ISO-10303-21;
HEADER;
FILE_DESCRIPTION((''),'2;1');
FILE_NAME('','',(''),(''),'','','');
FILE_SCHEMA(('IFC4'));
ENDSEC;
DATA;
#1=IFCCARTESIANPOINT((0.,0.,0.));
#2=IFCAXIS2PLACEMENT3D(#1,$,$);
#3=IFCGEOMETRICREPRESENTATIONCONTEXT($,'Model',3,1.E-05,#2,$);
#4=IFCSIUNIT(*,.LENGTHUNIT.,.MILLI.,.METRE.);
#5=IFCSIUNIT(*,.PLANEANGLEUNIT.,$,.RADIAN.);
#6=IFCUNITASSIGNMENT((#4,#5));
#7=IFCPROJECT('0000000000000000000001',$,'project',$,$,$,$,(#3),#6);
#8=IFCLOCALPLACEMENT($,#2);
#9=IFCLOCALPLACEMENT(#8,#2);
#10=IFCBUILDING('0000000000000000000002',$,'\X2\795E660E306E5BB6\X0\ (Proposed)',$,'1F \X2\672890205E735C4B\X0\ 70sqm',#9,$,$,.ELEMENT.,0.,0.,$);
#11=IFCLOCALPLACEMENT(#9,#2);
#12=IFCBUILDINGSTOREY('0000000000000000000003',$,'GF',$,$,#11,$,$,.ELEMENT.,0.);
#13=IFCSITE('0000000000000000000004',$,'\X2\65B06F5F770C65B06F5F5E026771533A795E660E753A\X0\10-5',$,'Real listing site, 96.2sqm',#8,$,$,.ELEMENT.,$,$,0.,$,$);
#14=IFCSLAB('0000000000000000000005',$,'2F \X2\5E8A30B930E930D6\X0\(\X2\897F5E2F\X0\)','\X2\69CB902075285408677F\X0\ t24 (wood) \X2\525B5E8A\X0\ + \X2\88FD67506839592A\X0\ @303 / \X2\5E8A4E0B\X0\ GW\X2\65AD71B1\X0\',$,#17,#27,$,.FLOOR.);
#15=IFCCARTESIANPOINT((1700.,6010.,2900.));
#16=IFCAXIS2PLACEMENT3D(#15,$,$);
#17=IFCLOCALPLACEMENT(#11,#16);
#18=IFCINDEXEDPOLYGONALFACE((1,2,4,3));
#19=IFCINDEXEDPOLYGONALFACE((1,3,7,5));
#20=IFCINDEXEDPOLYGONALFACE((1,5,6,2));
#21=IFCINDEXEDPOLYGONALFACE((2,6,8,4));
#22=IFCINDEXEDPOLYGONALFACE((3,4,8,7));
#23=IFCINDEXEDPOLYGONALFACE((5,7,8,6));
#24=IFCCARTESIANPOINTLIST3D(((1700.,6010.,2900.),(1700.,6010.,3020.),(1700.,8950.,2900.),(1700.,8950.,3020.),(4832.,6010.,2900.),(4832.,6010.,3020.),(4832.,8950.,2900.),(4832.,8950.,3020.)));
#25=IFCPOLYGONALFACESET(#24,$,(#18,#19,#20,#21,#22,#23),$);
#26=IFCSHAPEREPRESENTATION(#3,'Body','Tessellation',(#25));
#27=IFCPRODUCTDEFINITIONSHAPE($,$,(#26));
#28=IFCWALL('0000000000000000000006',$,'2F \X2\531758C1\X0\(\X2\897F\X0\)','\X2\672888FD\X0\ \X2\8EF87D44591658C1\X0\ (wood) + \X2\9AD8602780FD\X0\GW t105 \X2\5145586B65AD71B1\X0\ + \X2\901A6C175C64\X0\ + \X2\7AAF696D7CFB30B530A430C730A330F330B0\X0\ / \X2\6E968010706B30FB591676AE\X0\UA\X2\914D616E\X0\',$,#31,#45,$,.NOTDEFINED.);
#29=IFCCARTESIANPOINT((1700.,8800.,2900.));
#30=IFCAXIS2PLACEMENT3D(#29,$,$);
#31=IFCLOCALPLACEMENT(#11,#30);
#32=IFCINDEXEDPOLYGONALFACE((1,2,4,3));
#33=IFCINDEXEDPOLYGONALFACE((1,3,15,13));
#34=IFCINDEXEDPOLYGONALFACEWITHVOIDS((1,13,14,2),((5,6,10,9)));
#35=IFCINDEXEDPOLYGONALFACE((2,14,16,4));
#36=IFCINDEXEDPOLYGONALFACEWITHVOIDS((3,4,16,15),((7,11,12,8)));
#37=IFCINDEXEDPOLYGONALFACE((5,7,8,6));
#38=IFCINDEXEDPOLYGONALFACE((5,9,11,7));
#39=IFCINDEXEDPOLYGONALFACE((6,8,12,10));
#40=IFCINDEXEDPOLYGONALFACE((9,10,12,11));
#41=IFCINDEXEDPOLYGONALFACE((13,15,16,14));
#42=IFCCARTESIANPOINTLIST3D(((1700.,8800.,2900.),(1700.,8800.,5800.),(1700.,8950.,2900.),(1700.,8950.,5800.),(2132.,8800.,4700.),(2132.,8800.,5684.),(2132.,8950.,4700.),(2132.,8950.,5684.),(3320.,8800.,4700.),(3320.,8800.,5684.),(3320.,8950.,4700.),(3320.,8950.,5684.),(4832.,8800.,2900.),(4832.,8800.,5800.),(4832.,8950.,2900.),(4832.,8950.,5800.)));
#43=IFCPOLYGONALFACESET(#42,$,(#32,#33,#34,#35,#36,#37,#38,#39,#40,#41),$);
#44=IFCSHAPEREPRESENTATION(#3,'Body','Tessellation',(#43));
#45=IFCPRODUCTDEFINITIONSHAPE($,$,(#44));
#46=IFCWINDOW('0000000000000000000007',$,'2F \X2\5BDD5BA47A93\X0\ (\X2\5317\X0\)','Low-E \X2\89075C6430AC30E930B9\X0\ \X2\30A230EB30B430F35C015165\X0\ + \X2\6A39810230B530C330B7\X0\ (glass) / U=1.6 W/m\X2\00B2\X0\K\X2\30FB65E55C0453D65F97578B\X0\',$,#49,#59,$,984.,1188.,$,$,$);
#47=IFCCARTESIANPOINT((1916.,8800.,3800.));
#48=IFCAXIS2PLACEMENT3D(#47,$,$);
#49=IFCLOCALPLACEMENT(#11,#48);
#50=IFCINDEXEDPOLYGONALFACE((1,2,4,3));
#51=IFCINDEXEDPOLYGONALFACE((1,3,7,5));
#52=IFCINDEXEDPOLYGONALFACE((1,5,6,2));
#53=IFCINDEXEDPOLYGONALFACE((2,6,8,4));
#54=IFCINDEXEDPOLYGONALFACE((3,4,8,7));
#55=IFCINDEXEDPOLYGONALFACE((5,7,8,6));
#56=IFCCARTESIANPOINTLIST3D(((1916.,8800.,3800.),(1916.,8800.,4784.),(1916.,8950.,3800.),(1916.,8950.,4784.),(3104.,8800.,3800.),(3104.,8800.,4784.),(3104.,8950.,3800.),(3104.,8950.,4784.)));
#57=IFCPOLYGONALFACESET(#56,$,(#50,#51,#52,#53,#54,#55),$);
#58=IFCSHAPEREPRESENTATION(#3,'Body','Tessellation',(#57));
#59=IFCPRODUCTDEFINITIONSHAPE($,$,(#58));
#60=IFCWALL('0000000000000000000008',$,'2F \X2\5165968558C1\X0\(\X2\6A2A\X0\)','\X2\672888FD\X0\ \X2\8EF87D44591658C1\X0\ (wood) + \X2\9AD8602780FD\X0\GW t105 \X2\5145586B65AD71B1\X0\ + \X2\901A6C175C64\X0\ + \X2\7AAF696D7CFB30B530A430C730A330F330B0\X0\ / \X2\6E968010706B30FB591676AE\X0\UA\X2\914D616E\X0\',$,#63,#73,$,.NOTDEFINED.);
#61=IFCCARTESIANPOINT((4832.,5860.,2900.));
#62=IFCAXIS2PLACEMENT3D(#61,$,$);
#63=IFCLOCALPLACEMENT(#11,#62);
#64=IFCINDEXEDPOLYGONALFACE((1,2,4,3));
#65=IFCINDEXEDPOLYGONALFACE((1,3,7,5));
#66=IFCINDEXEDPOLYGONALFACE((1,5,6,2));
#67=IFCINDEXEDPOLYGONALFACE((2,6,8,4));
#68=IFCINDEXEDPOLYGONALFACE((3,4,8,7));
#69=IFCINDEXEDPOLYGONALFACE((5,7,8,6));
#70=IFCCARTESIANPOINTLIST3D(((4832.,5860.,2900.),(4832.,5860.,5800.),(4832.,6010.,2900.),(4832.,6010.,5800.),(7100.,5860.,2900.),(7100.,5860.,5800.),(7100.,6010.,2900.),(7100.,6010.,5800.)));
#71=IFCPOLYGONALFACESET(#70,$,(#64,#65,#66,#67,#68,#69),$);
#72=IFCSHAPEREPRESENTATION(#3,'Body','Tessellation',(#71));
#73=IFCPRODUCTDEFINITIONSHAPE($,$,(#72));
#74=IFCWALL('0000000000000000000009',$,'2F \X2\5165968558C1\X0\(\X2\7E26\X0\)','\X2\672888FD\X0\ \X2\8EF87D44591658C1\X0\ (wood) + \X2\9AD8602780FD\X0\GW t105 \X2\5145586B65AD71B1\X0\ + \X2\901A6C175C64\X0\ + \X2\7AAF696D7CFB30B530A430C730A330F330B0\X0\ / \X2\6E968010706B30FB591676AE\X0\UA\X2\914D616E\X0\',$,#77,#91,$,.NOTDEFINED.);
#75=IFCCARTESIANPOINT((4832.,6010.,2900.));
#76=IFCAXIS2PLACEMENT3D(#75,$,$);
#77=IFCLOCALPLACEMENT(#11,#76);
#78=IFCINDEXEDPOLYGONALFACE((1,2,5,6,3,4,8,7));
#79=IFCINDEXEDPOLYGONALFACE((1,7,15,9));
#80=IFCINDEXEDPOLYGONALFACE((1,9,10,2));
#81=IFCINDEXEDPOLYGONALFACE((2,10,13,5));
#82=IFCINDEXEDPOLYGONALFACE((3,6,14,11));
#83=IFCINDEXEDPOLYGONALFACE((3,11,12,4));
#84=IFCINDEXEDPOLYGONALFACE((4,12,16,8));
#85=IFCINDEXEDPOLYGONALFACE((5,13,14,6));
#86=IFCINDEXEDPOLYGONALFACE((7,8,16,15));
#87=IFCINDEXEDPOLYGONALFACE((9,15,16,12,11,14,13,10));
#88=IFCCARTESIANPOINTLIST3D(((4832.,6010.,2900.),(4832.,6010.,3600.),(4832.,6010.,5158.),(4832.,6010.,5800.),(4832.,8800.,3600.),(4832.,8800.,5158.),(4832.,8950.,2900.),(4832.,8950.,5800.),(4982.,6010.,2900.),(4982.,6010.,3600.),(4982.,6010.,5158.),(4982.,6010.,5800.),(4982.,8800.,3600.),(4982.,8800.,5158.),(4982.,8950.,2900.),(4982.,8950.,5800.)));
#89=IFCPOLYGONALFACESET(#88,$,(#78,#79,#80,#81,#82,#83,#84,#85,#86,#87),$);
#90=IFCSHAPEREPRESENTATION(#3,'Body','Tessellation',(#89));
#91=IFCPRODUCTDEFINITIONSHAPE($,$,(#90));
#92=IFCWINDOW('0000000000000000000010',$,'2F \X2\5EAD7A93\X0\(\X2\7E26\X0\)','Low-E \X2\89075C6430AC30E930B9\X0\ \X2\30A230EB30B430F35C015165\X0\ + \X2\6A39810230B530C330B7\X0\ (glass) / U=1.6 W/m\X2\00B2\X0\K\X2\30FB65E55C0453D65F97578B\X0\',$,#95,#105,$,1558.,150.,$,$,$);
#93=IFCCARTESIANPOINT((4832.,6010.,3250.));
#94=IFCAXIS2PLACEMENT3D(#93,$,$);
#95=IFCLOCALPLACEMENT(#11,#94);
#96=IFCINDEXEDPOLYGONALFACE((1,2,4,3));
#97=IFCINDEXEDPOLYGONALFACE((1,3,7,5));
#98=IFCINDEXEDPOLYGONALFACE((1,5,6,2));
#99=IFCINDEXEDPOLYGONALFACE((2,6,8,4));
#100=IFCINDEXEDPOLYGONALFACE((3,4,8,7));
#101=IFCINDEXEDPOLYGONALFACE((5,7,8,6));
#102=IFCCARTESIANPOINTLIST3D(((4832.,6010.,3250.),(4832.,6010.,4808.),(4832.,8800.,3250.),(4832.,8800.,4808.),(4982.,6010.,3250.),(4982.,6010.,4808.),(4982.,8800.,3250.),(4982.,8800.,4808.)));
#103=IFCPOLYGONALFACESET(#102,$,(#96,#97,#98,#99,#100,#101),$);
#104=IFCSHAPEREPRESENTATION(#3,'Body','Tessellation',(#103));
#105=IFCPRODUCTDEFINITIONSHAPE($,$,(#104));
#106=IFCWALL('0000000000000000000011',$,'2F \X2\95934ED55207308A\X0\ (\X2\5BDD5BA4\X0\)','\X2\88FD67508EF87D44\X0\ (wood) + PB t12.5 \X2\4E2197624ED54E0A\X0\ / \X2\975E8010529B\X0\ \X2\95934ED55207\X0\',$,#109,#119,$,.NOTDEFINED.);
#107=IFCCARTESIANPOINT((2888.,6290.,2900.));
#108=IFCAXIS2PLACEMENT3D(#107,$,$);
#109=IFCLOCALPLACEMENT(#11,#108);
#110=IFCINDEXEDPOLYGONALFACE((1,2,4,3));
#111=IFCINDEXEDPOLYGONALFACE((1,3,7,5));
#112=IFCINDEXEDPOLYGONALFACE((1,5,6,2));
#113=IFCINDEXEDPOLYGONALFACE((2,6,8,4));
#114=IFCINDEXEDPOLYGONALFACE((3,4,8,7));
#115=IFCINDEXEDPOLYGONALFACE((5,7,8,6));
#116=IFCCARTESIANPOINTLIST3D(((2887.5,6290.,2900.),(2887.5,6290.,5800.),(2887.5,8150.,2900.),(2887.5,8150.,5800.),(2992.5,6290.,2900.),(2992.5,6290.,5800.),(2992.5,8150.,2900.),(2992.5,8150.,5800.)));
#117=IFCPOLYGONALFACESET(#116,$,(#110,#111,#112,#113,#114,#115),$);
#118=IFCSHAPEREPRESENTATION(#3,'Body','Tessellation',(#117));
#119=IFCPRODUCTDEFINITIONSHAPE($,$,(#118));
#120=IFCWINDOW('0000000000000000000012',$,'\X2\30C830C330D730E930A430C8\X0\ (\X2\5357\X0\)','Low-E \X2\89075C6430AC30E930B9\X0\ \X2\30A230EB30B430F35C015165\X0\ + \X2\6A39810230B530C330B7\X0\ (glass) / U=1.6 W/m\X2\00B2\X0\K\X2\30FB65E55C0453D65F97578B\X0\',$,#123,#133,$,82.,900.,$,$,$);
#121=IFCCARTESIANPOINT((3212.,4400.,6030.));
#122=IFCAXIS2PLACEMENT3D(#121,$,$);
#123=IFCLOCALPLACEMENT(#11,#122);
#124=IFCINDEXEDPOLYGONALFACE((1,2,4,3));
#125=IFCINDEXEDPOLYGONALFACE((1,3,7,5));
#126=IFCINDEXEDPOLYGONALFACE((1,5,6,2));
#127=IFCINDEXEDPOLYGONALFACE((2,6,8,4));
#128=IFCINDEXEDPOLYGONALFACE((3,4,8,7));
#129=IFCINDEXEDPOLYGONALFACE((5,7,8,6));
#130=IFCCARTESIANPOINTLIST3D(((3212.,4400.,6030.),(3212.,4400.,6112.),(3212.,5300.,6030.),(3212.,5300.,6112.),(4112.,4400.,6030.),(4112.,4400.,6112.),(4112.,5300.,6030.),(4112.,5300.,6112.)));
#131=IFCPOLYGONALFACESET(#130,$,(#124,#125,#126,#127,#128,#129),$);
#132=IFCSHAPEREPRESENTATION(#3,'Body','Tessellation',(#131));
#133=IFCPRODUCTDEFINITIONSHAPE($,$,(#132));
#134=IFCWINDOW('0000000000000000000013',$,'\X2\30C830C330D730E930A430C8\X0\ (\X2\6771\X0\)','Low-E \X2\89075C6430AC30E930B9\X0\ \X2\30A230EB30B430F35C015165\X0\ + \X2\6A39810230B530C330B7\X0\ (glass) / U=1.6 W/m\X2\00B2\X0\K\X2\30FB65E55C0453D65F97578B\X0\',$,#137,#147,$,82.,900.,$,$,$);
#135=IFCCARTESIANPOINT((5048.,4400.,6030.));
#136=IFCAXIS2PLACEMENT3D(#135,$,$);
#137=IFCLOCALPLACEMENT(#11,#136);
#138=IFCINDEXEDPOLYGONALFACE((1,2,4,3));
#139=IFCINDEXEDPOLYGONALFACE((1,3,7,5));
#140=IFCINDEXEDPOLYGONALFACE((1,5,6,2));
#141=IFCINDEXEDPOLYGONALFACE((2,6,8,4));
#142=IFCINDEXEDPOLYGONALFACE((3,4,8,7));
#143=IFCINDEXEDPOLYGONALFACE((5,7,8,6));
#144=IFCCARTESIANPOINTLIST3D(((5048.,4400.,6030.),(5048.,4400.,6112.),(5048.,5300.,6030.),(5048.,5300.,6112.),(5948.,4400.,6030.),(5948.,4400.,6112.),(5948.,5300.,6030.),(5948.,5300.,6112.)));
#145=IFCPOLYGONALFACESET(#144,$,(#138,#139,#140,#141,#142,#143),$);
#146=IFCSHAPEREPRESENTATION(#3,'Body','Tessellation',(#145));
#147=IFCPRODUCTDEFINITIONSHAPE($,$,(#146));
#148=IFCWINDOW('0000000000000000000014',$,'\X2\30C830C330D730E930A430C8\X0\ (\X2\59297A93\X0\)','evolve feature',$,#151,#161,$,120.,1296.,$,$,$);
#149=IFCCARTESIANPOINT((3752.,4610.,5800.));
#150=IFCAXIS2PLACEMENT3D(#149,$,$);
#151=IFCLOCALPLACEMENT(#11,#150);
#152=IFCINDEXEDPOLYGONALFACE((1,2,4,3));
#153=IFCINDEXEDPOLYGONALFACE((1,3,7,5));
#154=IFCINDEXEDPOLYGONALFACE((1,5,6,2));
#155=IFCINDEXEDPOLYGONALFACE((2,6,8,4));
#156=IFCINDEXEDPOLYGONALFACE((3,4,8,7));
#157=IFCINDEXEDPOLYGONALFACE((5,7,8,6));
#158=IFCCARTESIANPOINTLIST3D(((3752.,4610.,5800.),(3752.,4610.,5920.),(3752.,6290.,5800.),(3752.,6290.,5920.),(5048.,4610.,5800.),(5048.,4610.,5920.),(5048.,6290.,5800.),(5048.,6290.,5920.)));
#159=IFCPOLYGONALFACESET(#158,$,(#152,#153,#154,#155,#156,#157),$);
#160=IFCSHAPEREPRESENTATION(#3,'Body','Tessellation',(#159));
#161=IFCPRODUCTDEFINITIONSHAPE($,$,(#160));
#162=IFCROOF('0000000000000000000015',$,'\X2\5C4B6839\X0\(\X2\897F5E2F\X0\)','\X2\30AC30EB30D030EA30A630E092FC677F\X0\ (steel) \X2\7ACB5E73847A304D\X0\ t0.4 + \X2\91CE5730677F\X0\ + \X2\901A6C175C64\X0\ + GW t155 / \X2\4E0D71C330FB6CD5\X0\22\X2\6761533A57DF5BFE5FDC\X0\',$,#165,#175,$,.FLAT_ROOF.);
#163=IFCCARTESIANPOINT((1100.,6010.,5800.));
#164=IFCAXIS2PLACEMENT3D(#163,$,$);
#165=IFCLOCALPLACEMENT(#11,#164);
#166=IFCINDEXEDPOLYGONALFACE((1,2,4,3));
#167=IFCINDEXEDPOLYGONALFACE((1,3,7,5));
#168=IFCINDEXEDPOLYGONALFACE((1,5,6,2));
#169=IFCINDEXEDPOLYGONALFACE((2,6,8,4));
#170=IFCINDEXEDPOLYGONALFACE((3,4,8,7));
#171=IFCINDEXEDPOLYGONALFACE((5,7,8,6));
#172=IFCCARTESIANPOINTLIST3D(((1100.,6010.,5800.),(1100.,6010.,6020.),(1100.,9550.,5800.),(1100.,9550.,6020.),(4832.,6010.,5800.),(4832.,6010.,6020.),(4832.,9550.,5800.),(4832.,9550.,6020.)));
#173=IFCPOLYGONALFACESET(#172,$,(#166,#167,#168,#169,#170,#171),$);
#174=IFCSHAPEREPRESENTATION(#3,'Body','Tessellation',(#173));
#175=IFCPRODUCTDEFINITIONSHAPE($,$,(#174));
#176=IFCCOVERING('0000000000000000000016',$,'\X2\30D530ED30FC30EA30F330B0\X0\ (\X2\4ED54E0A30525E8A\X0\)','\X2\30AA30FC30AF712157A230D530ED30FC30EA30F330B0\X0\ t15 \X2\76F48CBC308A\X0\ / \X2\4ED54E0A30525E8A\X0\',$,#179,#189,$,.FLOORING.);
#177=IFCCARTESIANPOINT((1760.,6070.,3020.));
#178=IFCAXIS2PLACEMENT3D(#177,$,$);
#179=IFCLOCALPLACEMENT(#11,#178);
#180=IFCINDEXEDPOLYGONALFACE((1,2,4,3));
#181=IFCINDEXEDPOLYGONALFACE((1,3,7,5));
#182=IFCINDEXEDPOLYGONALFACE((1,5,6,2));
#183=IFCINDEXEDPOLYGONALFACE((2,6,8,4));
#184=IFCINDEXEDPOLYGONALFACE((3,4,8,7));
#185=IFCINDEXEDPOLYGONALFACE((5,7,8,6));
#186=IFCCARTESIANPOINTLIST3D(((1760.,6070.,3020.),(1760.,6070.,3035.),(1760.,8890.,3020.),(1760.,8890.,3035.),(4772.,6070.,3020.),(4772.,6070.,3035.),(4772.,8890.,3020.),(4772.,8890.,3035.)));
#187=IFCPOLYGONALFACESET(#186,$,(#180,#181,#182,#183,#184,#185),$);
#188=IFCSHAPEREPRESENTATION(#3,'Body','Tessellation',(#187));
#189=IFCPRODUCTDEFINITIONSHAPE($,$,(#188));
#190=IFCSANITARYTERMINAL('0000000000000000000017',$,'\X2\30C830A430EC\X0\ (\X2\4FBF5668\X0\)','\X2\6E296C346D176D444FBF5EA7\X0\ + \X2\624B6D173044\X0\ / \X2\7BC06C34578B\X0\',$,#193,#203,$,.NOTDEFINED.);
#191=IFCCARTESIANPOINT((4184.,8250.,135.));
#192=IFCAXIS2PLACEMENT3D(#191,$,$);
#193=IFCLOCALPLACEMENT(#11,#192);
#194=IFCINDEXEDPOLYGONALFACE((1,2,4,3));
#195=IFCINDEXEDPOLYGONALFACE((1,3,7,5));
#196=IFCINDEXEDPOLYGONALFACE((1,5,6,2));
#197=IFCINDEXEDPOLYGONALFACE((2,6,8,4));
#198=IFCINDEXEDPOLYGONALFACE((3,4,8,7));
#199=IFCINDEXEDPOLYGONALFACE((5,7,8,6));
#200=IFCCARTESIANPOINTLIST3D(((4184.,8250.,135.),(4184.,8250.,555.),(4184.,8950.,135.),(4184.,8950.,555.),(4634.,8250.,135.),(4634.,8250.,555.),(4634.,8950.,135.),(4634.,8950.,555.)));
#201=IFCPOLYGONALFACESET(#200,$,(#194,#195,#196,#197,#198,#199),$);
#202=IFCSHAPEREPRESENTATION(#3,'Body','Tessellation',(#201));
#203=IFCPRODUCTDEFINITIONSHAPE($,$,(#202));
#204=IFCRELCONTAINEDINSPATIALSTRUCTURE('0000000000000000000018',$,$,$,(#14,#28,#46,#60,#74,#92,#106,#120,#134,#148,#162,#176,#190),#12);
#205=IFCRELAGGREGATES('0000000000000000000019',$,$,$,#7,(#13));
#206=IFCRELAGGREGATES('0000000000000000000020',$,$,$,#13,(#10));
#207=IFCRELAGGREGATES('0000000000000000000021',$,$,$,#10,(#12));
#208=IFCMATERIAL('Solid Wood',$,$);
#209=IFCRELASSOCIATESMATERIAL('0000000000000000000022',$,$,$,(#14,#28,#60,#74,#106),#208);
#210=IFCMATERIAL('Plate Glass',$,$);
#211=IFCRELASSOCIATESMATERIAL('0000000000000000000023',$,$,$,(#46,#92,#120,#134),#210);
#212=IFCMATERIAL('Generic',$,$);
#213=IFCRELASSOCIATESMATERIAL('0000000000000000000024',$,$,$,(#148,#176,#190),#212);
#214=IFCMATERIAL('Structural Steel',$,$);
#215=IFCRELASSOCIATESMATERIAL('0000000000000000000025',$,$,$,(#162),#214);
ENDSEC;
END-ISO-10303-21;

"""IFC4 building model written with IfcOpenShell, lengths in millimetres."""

from ifc_helpers import new_model, si_unit, frame, frame_2d, origin, place, context, project, spatial, rectangle, extrude, material, element, fill, save


model = new_model("IFC4")

# Units and contexts
model_context = context("Model", 3, precision=1e-05, world=origin())
ifc_project = project(units=[si_unit("LENGTHUNIT", "METRE", prefix="MILLI"), si_unit("PLANEANGLEUNIT", "RADIAN")], contexts=[model_context])

# Site, building, storey
site_placement = place(None, origin())
site = spatial("IfcSite", under=ifc_project, at=site_placement, Name="新潟県新潟市東区神明町10-5", ObjectType="Real listing site, 96.2sqm", CompositionType="ELEMENT", RefElevation=0.0)
building_placement = place(site_placement, origin())
building = spatial("IfcBuilding", under=site, at=building_placement, Name="神明の家 (Proposed)", ObjectType="1F 木造平屋 70sqm", CompositionType="ELEMENT", ElevationOfRefHeight=0.0, ElevationOfTerrain=0.0)
storey_placement = place(building_placement, origin())
storey = spatial("IfcBuildingStorey", under=building, at=storey_placement, Name="GF", CompositionType="ELEMENT", Elevation=0.0)

# Slab
ifc_material_1 = material(Name="Solid Wood")
slab_placement = place(storey_placement, frame((1700.0, 6010.0, 2900.0)))
element("IfcSlab", 1, at=slab_placement, inside=storey, material=ifc_material_1, Name="2F 床スラブ(西帯)", Description="構造用合板 t24 (wood) 剛床 + 製材根太 @303 / 床下 GW断熱", PredefinedType="FLOOR", context=model_context, shape_type="SweptSolid", body=[
    extrude(rectangle(XDim=3132.0, YDim=2940.0, at=frame_2d((1566.0, 1470.0))), frame((1700.0, 6010.0, 2900.0)), (0.0, 0.0, 1.0), 120.0),
])

# Wall, opening, window
wall_1_placement = place(storey_placement, frame((1700.0, 8800.0, 2900.0)))
wall_1 = element("IfcWall", 2, at=wall_1_placement, inside=storey, material=ifc_material_1, Name="2F 北壁(西)", Description="木製 軸組外壁 (wood) + 高性能GW t105 充填断熱 + 通気層 + 窯業系サイディング / 準耐火・外皮UA配慮", PredefinedType="NOTDEFINED", context=model_context, shape_type="SweptSolid", body=[
    extrude(rectangle(XDim=3132.0, YDim=150.0, at=frame_2d((1566.0, 75.0))), frame((1700.0, 8800.0, 2900.0)), (0.0, 0.0, 1.0), 2900.0),
])
opening_1_placement = place(storey_placement, frame((1916.0, 8800.0, 3800.0)))
opening_1 = element("IfcOpeningElement", 3, at=opening_1_placement, cuts=wall_1, PredefinedType="NOTDEFINED", context=model_context, shape_type="SweptSolid", body=[
    extrude(rectangle(XDim=1188.0, YDim=150.0, at=frame_2d((594.0, 75.0))), frame((1916.0, 8800.0, 3800.0)), (0.0, 0.0, 1.0), 984.0),
])
ifc_material_2 = material(Name="Plate Glass")
window_1_placement = place(storey_placement, frame((1916.0, 8800.0, 3800.0)))
window_1 = element("IfcWindow", 4, at=window_1_placement, inside=storey, material=ifc_material_2, Name="2F 寝室窓 (北)", Description="Low-E 複層ガラス アルゴン封入 + 樹脂サッシ (glass) / U=1.6 W/m²K・日射取得型", OverallHeight=984.0, OverallWidth=1188.0, context=model_context, shape_type="SweptSolid", body=[
    extrude(rectangle(XDim=1188.0, YDim=150.0, at=frame_2d((594.0, 75.0))), frame((1916.0, 8800.0, 3800.0)), (0.0, 0.0, 1.0), 984.0),
])
fill(opening_1, window_1)

# Wall
wall_2_placement = place(storey_placement, frame((4832.0, 5860.0, 2900.0)))
element("IfcWall", 5, at=wall_2_placement, inside=storey, material=ifc_material_1, Name="2F 入隅壁(横)", Description="木製 軸組外壁 (wood) + 高性能GW t105 充填断熱 + 通気層 + 窯業系サイディング / 準耐火・外皮UA配慮", PredefinedType="NOTDEFINED", context=model_context, shape_type="SweptSolid", body=[
    extrude(rectangle(XDim=2268.0, YDim=150.0, at=frame_2d((1134.0, 75.0))), frame((4832.0, 5860.0, 2900.0)), (0.0, 0.0, 1.0), 2900.0),
])

# Wall, opening, window
wall_3_placement = place(storey_placement, frame((4832.0, 6010.0, 2900.0)))
wall_3 = element("IfcWall", 6, at=wall_3_placement, inside=storey, material=ifc_material_1, Name="2F 入隅壁(縦)", Description="木製 軸組外壁 (wood) + 高性能GW t105 充填断熱 + 通気層 + 窯業系サイディング / 準耐火・外皮UA配慮", PredefinedType="NOTDEFINED", context=model_context, shape_type="SweptSolid", body=[
    extrude(rectangle(XDim=150.0, YDim=2940.0, at=frame_2d((75.0, 1470.0))), frame((4832.0, 6010.0, 2900.0)), (0.0, 0.0, 1.0), 2900.0),
])
opening_2_placement = place(storey_placement, frame((4832.0, 6010.0, 3250.0)))
opening_2 = element("IfcOpeningElement", 7, at=opening_2_placement, cuts=wall_3, PredefinedType="NOTDEFINED", context=model_context, shape_type="SweptSolid", body=[
    extrude(rectangle(XDim=150.0, YDim=2790.0, at=frame_2d((75.0, 1395.0))), frame((4832.0, 6010.0, 3250.0)), (0.0, 0.0, 1.0), 1558.0),
])
window_2_placement = place(storey_placement, frame((4832.0, 6010.0, 3250.0)))
window_2 = element("IfcWindow", 8, at=window_2_placement, inside=storey, material=ifc_material_2, Name="2F 庭窓(縦)", Description="Low-E 複層ガラス アルゴン封入 + 樹脂サッシ (glass) / U=1.6 W/m²K・日射取得型", OverallHeight=1558.0, OverallWidth=150.0, context=model_context, shape_type="SweptSolid", body=[
    extrude(rectangle(XDim=150.0, YDim=2790.0, at=frame_2d((75.0, 1395.0))), frame((4832.0, 6010.0, 3250.0)), (0.0, 0.0, 1.0), 1558.0),
])
fill(opening_2, window_2)

# Wall
wall_4_placement = place(storey_placement, frame((2888.0, 6290.0, 2900.0)))
element("IfcWall", 9, at=wall_4_placement, inside=storey, material=ifc_material_1, Name="2F 間仕切り (寝室)", Description="製材軸組 (wood) + PB t12.5 両面仕上 / 非耐力 間仕切", PredefinedType="NOTDEFINED", context=model_context, shape_type="SweptSolid", body=[
    extrude(rectangle(XDim=105.0, YDim=1860.0, at=frame_2d((52.0, 930.0))), frame((2888.0, 6290.0, 2900.0)), (0.0, 0.0, 1.0), 2900.0),
])

# Windows
window_3_placement = place(storey_placement, frame((3212.0, 4400.0, 6030.0)))
element("IfcWindow", 10, at=window_3_placement, inside=storey, material=ifc_material_2, Name="トップライト (南)", Description="Low-E 複層ガラス アルゴン封入 + 樹脂サッシ (glass) / U=1.6 W/m²K・日射取得型", OverallHeight=82.0, OverallWidth=900.0, context=model_context, shape_type="SweptSolid", body=[
    extrude(rectangle(XDim=900.0, YDim=900.0, at=frame_2d((450.0, 450.0))), frame((3212.0, 4400.0, 6030.0)), (0.0, 0.0, 1.0), 82.0),
])
window_4_placement = place(storey_placement, frame((5048.0, 4400.0, 6030.0)))
element("IfcWindow", 11, at=window_4_placement, inside=storey, material=ifc_material_2, Name="トップライト (東)", Description="Low-E 複層ガラス アルゴン封入 + 樹脂サッシ (glass) / U=1.6 W/m²K・日射取得型", OverallHeight=82.0, OverallWidth=900.0, context=model_context, shape_type="SweptSolid", body=[
    extrude(rectangle(XDim=900.0, YDim=900.0, at=frame_2d((450.0, 450.0))), frame((5048.0, 4400.0, 6030.0)), (0.0, 0.0, 1.0), 82.0),
])
ifc_material_3 = material(Name="Generic")
window_5_placement = place(storey_placement, frame((3752.0, 4610.0, 5800.0)))
element("IfcWindow", 12, at=window_5_placement, inside=storey, material=ifc_material_3, Name="トップライト (天窓)", Description="evolve feature", OverallHeight=120.0, OverallWidth=1296.0, context=model_context, shape_type="SweptSolid", body=[
    extrude(rectangle(XDim=1296.0, YDim=1680.0, at=frame_2d((648.0, 840.0))), frame((3752.0, 4610.0, 5800.0)), (0.0, 0.0, 1.0), 120.0),
])

# Roof
ifc_material_4 = material(Name="Structural Steel")
for number, where, name in (
    (13, (1100.0, 6010.0, 5800.0), "屋根(西帯)"),
):
    element("IfcRoof", number, at=place(storey_placement, frame(where)), inside=storey, material=ifc_material_4, Name=name, Description="ガルバリウム鋼板 (steel) 立平葺き t0.4 + 野地板 + 通気層 + GW t155 / 不燃・法22条区域対応", PredefinedType="FLAT_ROOF", context=model_context, shape_type="SweptSolid", body=[
        extrude(rectangle(XDim=3732.0, YDim=3540.0, at=frame_2d((1866.0, 1770.0))), frame((1100.0, 6010.0, 5800.0)), (0.0, 0.0, 1.0), 220.0),
    ])

# Covering
covering_placement = place(storey_placement, frame((1760.0, 6070.0, 3020.0)))
element("IfcCovering", 14, at=covering_placement, inside=storey, material=ifc_material_3, Name="フローリング (仕上げ床)", Description="オーク無垢フローリング t15 直貼り / 仕上げ床", PredefinedType="FLOORING", context=model_context, shape_type="SweptSolid", body=[
    extrude(rectangle(XDim=3012.0, YDim=2820.0, at=frame_2d((1506.0, 1410.0))), frame((1760.0, 6070.0, 3020.0)), (0.0, 0.0, 1.0), 15.0),
])

# Sanitary terminal
sanitary_terminal_placement = place(storey_placement, frame((4184.0, 8250.0, 135.0)))
element("IfcSanitaryTerminal", 15, at=sanitary_terminal_placement, inside=storey, material=ifc_material_3, Name="トイレ (便器)", Description="温水洗浄便座 + 手洗い / 節水型", PredefinedType="NOTDEFINED", context=model_context, shape_type="SweptSolid", body=[
    extrude(rectangle(XDim=450.0, YDim=700.0, at=frame_2d((225.0, 350.0))), frame((4184.0, 8250.0, 135.0)), (0.0, 0.0, 1.0), 420.0),
])

save(model, "model.ifc")
